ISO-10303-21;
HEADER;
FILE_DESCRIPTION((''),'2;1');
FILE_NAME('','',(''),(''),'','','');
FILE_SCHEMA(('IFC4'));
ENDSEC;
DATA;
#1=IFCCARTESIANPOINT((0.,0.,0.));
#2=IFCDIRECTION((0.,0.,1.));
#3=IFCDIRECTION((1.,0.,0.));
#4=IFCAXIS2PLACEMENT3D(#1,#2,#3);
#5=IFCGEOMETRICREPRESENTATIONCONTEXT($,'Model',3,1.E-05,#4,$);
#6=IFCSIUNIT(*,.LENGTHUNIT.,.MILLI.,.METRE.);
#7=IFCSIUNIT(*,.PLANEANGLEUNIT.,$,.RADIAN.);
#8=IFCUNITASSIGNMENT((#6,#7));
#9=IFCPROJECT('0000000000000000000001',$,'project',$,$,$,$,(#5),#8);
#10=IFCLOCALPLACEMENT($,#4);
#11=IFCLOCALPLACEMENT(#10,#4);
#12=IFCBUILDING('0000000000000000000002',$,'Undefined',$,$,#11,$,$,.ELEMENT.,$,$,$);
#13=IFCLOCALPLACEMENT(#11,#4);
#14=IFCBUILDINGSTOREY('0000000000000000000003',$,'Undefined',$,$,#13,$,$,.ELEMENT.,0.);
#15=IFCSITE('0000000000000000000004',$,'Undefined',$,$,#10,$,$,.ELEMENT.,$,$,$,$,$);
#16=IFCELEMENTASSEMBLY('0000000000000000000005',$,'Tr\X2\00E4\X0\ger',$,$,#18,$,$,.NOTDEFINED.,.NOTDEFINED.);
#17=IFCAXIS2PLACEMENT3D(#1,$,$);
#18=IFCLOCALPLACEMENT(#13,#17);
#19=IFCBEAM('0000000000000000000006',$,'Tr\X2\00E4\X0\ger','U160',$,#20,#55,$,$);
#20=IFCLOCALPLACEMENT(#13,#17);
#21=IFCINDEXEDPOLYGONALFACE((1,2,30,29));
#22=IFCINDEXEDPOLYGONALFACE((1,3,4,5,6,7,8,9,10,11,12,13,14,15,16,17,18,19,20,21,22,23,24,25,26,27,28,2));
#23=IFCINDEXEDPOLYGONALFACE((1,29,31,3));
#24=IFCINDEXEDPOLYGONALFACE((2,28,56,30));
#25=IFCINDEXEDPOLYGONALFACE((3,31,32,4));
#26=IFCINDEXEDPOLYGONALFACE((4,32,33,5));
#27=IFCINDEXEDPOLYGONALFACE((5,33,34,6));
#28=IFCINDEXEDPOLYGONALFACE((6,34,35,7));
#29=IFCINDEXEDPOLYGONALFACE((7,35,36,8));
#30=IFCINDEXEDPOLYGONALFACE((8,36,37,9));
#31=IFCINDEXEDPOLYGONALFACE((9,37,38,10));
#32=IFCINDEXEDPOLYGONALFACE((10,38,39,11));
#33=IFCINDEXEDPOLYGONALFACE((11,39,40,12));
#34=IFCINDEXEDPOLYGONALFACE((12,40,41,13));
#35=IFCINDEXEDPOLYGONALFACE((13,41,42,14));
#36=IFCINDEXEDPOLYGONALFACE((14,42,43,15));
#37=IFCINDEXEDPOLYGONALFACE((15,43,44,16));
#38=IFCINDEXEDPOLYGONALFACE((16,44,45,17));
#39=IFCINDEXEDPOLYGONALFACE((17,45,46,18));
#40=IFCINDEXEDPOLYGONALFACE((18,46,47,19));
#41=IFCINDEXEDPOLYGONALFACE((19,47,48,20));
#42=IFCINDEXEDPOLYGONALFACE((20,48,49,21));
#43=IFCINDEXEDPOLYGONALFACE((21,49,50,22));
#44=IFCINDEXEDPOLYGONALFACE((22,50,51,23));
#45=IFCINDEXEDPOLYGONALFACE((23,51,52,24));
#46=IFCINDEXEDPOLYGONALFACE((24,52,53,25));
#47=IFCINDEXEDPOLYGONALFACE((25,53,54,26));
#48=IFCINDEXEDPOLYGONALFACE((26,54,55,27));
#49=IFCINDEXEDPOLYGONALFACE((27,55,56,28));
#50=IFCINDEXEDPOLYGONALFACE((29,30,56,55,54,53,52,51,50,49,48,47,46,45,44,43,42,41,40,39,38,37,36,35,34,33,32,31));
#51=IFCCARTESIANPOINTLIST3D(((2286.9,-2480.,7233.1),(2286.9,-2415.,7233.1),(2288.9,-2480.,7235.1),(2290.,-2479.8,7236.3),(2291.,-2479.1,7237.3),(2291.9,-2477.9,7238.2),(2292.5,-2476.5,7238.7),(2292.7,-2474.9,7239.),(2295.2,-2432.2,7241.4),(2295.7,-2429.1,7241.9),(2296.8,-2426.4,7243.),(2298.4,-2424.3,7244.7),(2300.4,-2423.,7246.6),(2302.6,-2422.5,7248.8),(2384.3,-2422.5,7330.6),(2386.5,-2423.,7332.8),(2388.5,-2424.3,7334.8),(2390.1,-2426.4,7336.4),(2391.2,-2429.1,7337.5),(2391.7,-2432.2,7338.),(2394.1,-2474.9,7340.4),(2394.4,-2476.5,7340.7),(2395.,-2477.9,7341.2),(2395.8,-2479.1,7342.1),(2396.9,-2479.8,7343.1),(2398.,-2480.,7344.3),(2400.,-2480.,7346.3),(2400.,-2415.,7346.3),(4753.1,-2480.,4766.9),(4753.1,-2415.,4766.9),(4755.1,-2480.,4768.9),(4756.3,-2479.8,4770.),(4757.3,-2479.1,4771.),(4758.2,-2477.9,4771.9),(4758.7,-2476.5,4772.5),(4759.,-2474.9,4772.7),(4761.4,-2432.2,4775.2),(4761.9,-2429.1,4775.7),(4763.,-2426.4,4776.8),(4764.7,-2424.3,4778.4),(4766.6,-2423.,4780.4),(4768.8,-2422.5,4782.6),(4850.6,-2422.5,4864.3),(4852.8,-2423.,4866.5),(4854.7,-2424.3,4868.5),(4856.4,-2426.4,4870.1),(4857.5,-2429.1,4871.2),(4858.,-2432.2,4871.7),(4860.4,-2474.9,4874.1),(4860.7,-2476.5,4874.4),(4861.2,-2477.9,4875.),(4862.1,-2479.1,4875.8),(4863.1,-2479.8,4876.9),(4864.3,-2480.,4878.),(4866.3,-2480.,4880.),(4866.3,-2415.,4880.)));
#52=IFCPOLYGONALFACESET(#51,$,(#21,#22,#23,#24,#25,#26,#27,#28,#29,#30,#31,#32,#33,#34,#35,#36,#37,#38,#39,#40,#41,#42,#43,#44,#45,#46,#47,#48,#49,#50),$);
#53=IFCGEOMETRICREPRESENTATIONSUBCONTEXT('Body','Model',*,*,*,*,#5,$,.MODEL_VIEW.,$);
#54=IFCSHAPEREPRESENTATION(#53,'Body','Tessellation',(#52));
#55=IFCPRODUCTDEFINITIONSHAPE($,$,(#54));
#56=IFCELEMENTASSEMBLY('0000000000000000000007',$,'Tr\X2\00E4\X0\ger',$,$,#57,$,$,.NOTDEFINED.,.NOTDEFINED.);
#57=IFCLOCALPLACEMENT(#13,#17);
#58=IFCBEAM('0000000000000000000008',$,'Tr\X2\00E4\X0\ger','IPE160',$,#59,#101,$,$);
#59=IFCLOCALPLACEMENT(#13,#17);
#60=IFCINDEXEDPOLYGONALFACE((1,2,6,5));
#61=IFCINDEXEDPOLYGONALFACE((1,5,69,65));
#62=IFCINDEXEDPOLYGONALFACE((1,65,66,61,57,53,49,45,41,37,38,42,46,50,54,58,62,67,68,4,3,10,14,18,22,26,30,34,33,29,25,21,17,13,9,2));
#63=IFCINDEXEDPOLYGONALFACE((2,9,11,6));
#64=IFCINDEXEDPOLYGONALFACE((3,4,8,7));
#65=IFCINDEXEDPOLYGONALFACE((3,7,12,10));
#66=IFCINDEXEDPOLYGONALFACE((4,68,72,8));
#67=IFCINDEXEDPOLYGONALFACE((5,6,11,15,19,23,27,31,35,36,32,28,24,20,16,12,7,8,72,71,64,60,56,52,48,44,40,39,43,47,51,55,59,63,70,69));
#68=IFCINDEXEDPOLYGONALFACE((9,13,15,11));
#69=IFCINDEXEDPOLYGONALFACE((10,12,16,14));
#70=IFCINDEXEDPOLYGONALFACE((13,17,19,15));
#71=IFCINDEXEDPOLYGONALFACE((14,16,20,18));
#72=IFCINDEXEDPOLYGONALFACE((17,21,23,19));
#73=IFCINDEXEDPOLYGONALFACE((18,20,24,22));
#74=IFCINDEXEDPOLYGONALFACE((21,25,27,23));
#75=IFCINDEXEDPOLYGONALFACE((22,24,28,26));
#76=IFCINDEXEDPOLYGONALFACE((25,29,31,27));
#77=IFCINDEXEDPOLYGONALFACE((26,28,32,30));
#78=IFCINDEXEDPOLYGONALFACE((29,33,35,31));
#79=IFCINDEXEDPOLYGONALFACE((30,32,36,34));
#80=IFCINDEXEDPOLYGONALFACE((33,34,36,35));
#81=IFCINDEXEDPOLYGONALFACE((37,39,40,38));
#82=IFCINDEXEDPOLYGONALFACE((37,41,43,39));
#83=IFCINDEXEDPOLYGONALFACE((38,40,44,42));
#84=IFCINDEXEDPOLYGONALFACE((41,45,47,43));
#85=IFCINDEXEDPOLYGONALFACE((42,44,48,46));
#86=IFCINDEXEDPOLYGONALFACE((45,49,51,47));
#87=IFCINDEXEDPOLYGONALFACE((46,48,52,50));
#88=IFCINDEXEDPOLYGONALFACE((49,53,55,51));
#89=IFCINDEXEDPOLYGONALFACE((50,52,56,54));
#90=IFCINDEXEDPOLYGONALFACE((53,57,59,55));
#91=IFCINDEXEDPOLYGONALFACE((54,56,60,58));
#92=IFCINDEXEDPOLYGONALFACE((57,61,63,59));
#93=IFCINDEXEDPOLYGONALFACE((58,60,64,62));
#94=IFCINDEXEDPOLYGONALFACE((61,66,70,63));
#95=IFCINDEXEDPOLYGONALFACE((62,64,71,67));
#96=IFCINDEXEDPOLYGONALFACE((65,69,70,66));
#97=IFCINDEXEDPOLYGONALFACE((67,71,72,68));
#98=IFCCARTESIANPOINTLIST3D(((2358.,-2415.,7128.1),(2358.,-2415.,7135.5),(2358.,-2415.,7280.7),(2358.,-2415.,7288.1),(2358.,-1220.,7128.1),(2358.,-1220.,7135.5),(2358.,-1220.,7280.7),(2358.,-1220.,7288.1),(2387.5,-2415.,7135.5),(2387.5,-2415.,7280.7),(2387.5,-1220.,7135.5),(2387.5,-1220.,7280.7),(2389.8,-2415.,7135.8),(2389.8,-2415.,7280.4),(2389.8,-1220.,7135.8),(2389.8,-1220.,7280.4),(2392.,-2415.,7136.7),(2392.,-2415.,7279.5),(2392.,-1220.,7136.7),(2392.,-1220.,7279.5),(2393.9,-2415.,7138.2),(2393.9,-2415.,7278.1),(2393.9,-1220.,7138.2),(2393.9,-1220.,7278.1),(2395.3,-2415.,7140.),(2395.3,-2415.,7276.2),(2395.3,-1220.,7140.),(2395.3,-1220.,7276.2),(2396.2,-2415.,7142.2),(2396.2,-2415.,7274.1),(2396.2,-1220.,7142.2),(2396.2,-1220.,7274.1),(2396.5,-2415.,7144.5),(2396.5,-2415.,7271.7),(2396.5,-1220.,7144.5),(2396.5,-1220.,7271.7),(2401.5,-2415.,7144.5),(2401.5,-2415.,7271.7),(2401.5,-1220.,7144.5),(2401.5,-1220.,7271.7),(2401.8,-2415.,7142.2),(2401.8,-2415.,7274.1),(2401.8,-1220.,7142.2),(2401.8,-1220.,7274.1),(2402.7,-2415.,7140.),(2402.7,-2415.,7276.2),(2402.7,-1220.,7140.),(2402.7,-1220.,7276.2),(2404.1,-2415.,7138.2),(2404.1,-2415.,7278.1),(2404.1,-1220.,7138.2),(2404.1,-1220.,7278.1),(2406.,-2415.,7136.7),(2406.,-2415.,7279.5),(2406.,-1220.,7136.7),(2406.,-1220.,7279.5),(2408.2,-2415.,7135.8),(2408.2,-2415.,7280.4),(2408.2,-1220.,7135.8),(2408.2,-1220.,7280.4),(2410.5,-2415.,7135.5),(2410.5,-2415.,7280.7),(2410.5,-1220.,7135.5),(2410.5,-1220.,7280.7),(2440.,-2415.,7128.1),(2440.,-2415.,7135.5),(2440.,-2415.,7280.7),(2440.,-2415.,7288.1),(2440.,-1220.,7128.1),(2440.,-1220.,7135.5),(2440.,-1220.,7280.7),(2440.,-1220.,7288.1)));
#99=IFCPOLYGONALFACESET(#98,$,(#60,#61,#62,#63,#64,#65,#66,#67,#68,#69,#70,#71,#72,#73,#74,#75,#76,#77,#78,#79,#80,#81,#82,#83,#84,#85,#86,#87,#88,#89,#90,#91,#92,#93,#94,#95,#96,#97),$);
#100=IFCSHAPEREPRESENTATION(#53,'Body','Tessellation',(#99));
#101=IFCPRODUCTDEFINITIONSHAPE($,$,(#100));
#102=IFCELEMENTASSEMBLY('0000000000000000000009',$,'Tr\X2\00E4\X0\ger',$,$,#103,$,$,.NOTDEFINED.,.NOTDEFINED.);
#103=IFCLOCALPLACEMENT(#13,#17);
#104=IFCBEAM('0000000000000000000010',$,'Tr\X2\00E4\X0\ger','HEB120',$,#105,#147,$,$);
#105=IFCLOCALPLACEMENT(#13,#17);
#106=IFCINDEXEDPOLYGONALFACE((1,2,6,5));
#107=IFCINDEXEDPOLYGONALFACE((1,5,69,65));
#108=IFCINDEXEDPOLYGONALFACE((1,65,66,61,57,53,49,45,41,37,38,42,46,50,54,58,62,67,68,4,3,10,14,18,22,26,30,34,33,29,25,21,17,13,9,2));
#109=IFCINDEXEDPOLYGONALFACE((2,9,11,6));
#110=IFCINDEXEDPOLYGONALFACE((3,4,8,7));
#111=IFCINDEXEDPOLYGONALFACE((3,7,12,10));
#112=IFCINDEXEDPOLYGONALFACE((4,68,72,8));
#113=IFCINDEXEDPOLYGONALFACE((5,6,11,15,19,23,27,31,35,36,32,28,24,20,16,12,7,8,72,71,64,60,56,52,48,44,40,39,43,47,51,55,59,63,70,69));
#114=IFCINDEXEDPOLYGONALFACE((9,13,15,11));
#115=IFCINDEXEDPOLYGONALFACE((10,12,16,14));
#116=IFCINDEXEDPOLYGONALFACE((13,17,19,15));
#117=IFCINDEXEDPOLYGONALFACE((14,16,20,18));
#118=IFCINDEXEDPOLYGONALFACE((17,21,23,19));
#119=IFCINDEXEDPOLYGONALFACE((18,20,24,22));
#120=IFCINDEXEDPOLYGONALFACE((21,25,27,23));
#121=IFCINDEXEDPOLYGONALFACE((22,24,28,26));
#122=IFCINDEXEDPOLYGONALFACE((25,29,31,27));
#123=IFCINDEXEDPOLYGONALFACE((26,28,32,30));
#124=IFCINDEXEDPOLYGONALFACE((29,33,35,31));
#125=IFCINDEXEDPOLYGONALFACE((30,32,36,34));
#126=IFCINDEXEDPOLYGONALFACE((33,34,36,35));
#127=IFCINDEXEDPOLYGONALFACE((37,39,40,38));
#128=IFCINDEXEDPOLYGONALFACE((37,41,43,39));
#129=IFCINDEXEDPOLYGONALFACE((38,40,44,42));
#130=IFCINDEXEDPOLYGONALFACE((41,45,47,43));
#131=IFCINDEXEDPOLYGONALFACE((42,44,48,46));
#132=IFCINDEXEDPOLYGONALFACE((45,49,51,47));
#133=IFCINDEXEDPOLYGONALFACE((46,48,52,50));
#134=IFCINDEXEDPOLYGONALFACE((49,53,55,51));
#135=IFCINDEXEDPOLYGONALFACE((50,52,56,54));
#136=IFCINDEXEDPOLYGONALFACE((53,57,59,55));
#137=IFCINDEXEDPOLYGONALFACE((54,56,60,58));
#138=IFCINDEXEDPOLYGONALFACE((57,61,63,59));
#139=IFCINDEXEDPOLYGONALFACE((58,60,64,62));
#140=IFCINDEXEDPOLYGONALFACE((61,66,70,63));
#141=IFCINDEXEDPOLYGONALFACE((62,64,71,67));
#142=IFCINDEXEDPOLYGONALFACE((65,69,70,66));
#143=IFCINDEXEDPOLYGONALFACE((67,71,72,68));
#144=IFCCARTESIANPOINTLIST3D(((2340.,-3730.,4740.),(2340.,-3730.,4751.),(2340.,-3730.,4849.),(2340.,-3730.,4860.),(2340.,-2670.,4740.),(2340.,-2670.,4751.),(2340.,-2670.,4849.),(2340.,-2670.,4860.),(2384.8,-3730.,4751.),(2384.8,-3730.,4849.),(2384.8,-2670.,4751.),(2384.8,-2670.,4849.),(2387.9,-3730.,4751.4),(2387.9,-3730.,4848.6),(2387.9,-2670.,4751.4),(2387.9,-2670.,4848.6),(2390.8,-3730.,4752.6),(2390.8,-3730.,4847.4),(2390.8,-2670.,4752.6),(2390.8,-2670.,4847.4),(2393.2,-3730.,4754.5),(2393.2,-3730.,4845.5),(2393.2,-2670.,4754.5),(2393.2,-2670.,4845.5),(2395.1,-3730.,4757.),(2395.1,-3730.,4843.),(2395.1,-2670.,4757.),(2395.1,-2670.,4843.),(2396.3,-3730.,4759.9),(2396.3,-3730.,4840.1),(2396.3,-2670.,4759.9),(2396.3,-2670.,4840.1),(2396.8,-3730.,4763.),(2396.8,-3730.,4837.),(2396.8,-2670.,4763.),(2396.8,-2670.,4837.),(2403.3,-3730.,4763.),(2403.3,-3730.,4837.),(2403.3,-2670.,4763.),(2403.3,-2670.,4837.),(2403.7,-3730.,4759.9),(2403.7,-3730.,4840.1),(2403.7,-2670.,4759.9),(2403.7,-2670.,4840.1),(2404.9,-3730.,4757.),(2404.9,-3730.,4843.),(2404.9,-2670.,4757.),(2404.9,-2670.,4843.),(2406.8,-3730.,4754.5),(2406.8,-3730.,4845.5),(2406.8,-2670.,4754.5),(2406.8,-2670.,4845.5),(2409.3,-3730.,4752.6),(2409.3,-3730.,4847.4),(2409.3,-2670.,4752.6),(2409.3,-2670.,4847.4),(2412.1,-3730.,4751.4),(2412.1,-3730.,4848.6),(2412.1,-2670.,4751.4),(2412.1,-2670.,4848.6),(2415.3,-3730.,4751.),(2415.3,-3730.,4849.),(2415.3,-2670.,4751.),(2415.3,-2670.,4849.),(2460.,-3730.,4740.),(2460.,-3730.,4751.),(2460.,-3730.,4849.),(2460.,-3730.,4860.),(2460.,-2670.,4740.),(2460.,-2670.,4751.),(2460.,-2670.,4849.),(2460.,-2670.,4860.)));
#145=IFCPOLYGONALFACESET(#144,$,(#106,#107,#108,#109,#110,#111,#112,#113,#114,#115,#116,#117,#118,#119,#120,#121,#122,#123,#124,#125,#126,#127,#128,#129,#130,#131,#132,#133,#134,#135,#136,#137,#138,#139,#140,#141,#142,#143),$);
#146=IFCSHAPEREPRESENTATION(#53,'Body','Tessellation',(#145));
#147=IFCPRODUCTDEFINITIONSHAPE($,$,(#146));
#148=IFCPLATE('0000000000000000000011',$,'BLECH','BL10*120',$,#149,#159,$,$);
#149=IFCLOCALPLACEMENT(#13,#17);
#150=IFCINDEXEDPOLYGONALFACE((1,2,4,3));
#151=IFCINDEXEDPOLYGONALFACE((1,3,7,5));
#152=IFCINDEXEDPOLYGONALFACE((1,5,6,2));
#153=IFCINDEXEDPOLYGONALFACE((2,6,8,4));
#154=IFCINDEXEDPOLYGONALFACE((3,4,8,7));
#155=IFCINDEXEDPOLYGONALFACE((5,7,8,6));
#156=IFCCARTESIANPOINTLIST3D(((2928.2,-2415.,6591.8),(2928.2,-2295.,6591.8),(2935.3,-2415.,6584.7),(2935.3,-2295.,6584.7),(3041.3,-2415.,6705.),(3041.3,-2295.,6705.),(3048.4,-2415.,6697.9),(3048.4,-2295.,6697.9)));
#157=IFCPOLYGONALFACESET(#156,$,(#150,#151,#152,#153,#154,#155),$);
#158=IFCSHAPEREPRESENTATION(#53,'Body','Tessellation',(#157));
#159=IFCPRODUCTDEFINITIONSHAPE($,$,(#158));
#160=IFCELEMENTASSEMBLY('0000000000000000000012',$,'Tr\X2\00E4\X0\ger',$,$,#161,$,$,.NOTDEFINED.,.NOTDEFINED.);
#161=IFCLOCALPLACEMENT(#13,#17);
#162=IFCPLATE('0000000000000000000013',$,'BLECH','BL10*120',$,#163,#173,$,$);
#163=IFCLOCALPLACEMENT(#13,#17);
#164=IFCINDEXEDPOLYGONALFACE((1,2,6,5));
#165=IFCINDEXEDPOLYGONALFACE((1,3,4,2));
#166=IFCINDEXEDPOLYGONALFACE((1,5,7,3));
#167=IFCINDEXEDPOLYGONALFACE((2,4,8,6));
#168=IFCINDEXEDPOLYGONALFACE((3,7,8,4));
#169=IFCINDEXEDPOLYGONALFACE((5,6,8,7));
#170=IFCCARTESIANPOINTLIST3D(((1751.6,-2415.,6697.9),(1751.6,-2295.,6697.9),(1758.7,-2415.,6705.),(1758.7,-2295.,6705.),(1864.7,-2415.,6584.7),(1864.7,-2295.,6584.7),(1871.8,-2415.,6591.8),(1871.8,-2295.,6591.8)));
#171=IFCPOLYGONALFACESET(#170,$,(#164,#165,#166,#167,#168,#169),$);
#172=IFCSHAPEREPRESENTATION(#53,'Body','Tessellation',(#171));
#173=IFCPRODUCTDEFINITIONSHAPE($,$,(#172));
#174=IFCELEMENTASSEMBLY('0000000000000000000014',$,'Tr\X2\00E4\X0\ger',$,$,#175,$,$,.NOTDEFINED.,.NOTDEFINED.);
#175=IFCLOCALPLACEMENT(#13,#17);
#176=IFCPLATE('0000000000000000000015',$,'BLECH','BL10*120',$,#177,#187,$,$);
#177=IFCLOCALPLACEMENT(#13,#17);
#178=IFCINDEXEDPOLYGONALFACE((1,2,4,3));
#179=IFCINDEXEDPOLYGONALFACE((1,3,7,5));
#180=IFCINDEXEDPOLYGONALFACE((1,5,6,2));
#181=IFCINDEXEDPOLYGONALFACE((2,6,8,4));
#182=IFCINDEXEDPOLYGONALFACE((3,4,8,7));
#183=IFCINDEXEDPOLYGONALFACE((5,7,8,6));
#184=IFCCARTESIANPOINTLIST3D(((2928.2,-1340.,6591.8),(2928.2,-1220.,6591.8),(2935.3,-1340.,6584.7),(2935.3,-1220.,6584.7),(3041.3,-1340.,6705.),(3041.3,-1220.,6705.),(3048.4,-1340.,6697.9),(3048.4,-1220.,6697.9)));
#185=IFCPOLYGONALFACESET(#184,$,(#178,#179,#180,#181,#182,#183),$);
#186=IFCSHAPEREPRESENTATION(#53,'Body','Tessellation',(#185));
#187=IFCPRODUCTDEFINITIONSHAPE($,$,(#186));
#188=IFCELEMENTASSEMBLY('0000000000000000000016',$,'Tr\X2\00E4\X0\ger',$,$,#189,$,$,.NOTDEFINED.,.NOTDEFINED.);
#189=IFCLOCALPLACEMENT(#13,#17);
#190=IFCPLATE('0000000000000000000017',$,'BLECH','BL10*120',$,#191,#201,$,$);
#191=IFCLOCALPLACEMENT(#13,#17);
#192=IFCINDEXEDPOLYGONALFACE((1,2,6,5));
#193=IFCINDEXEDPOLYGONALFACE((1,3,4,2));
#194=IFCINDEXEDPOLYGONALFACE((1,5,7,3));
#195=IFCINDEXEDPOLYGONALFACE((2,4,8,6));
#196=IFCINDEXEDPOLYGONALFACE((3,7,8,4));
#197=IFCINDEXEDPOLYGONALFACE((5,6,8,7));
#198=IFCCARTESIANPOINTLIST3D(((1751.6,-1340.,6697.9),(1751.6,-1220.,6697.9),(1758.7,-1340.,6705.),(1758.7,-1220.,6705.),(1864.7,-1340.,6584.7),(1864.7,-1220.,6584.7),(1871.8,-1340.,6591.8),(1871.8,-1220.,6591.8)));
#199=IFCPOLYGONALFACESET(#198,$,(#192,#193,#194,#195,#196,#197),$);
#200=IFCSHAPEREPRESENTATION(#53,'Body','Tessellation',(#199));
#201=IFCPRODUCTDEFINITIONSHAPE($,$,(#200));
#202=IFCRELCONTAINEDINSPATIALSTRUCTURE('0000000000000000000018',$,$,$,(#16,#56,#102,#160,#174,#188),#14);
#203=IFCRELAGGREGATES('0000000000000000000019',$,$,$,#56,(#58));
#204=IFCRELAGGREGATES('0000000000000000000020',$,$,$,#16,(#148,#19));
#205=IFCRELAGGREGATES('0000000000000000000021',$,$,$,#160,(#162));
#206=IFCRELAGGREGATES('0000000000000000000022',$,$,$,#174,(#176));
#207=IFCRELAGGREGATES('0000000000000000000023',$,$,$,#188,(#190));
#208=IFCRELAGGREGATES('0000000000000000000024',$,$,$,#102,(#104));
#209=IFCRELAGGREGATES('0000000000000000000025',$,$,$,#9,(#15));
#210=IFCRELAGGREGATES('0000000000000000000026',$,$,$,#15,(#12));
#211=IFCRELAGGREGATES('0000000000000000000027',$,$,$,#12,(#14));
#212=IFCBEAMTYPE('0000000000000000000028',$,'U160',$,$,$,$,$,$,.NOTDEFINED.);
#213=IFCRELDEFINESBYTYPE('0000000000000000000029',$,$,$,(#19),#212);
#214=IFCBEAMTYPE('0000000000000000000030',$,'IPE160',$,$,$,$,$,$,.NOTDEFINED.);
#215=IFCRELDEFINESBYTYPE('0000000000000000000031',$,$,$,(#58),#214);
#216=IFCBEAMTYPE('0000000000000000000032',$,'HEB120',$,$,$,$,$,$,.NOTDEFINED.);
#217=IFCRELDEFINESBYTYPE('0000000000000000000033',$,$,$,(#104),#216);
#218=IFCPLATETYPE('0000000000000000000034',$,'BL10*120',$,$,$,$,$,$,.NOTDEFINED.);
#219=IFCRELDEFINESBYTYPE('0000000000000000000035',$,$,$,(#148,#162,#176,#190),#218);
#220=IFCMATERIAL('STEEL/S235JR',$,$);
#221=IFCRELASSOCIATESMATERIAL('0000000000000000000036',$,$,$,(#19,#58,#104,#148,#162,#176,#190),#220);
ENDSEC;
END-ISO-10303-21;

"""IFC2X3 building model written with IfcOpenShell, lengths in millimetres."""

from ifc_helpers import new_model, si_unit, frame, origin_with_axes, origin_2d_with_axis, place, context, subcontext, project, spatial, polyline, i_section, u_section, outline, extrude, clip, halfspace, material, type_object, element, aggregate, save


model = new_model("IFC2X3")

# Units and contexts
model_context = context("Model", 3, precision=1e-05, world=origin_with_axes())
body_context = subcontext(model_context, "Body", "Model", "MODEL_VIEW")
ifc_project = project(units=[si_unit("LENGTHUNIT", "METRE", prefix="MILLI"), si_unit("PLANEANGLEUNIT", "RADIAN")], contexts=[model_context])

# Site, building, storey
site_placement = place(None, origin_with_axes())
site = spatial("IfcSite", under=ifc_project, at=site_placement, Name="Undefined", CompositionType="ELEMENT")
building_placement = place(site_placement, origin_with_axes())
building = spatial("IfcBuilding", under=site, at=building_placement, Name="Undefined", CompositionType="ELEMENT")
storey_placement = place(building_placement, origin_with_axes())
storey = spatial("IfcBuildingStorey", under=building, at=storey_placement, Name="Undefined", CompositionType="ELEMENT", Elevation=0.0)

# Element assemblies, beams
assembly_1_placement = place(storey_placement, origin_with_axes())
assembly_1 = element("IfcElementAssembly", 1, at=assembly_1_placement, inside=storey, Name="Träger", AssemblyPlace="NOTDEFINED", PredefinedType="NOTDEFINED")
ifc_material_1 = material(Name="STEEL/S235JR")
beam_type_1 = type_object("IfcBeamType", Name="U160", PredefinedType="NOTDEFINED")
beam_1_placement = place(assembly_1_placement, frame((2343.4, -2447.5, 7289.7), z_axis=(0.707107, 0.0, 0.707107), x_axis=(0.707107, 0.0, -0.707107)))
beam_1 = element("IfcBeam", 2, at=beam_1_placement, type_object=beam_type_1, material=ifc_material_1, Name="Träger", Description="U160", context=body_context, shape_type="SweptSolid", body=[
    extrude(u_section(Depth=160.0, FlangeWidth=65.0, WebThickness=7.5, FlangeThickness=10.5, FilletRadius=10.5, EdgeRadius=5.5, FlangeSlope=0.07983, at=origin_2d_with_axis()), frame((3487.8, 0.0, 0.0), z_axis=(-1.0, 0.0, 0.0), x_axis=(0.0, -1.0, 0.0)), (0.0, 0.0, 1.0), 3487.8),
])
assembly_2_placement = place(storey_placement, origin_with_axes())
assembly_2 = element("IfcElementAssembly", 3, at=assembly_2_placement, inside=storey, Name="Träger", AssemblyPlace="NOTDEFINED", PredefinedType="NOTDEFINED")
beam_type_2 = type_object("IfcBeamType", Name="IPE160", PredefinedType="NOTDEFINED")
beam_2_placement = place(assembly_2_placement, frame((2399.0, -1220.0, 7208.1), z_axis=(0.0, 0.0, 1.0), x_axis=(0.0, -1.0, 0.0)))
beam_2 = element("IfcBeam", 4, at=beam_2_placement, type_object=beam_type_2, material=ifc_material_1, Name="Träger", Description="IPE160", context=body_context, shape_type="SweptSolid", body=[
    extrude(i_section(OverallWidth=82.0, OverallDepth=160.0, WebThickness=5.0, FlangeThickness=7.4, FilletRadius=9.0, at=origin_2d_with_axis()), frame((1195.0, 0.0, 0.0), z_axis=(-1.0, 0.0, 0.0), x_axis=(0.0, -1.0, 0.0)), (0.0, 0.0, 1.0), 1195.0),
])
aggregate(assembly_2, [beam_2])
beam_type_3 = type_object("IfcBeamType", Name="HEB120", PredefinedType="NOTDEFINED")

# Element assembly, beam
assembly_3_placement = place(storey_placement, origin_with_axes())
assembly_3 = element("IfcElementAssembly", 5, at=assembly_3_placement, inside=storey, Name="Träger", AssemblyPlace="NOTDEFINED", PredefinedType="NOTDEFINED")
beam_3_placement = place(assembly_3_placement, frame((2400.0, -2670.0, 4800.0), z_axis=(0.0, 0.0, 1.0), x_axis=(0.0, -1.0, 0.0)))
beam_3 = element("IfcBeam", 6, at=beam_3_placement, type_object=beam_type_3, material=ifc_material_1, Name="Träger", Description="HEB120", context=body_context, shape_type="Clipping", body=[
    clip(clip(extrude(i_section(OverallWidth=120.0, OverallDepth=120.0, WebThickness=6.5, FlangeThickness=11.0, FilletRadius=12.0, at=origin_2d_with_axis()), frame((1060.0, 0.0, 0.0), z_axis=(-1.0, 0.0, 0.0), x_axis=(0.0, -1.0, 0.0)), (0.0, 0.0, 1.0), 1060.0), halfspace(frame((1060.0, 0.0, -60.0), z_axis=(-1.0, 0.0, 0.0), x_axis=(0.0, 1.0, 0.0)), True)), halfspace(frame((0.0, 0.0, -60.0), z_axis=(1.0, 0.0, 0.0), x_axis=(0.0, -1.0, 0.0)), True)),
])

# Plate
plate_type = type_object("IfcPlateType", Name="BL10*120", PredefinedType="NOTDEFINED")
plate_1_placement = place(assembly_1_placement, frame((2931.7, -2295.0, 6588.3), z_axis=(-0.707107, 0.0, 0.707107), x_axis=(0.0, -1.0, 0.0)))
plate_1 = element("IfcPlate", 7, at=plate_1_placement, type_object=plate_type, material=ifc_material_1, Name="BLECH", Description="BL10*120", context=body_context, shape_type="SweptSolid", body=[
    extrude(outline(polyline([(0.0, 0.0), (120.0, 0.0), (120.0, 160.0), (0.0, 160.0), (0.0, 0.0)])), frame((0.0, 0.0, -5.0), z_axis=(0.0, 0.0, 1.0), x_axis=(1.0, 0.0, 0.0)), (0.0, 0.0, 1.0), 10.0),
])

# Element assemblies, plates
assembly_4_placement = place(storey_placement, origin_with_axes())
assembly_4 = element("IfcElementAssembly", 8, at=assembly_4_placement, inside=storey, Name="Träger", AssemblyPlace="NOTDEFINED", PredefinedType="NOTDEFINED")
plate_2_placement = place(assembly_4_placement, frame((1868.3, -2295.0, 6588.3), z_axis=(-0.707107, 0.0, -0.707107), x_axis=(0.0, -1.0, 0.0)))
plate_2 = element("IfcPlate", 9, at=plate_2_placement, type_object=plate_type, material=ifc_material_1, Name="BLECH", Description="BL10*120", context=body_context, shape_type="SweptSolid", body=[
    extrude(outline(polyline([(0.0, 0.0), (120.0, 0.0), (120.0, 160.0), (0.0, 160.0), (0.0, 0.0)])), frame((0.0, 0.0, -5.0), z_axis=(0.0, 0.0, 1.0), x_axis=(1.0, 0.0, 0.0)), (0.0, 0.0, 1.0), 10.0),
])
assembly_5_placement = place(storey_placement, origin_with_axes())
assembly_5 = element("IfcElementAssembly", 10, at=assembly_5_placement, inside=storey, Name="Träger", AssemblyPlace="NOTDEFINED", PredefinedType="NOTDEFINED")
plate_3_placement = place(assembly_5_placement, frame((2931.7, -1340.0, 6588.3), z_axis=(0.707107, 0.0, -0.707107), x_axis=(0.0, 1.0, 0.0)))
plate_3 = element("IfcPlate", 11, at=plate_3_placement, type_object=plate_type, material=ifc_material_1, Name="BLECH", Description="BL10*120", context=body_context, shape_type="SweptSolid", body=[
    extrude(outline(polyline([(0.0, 0.0), (120.0, 0.0), (120.0, 160.0), (0.0, 160.0), (0.0, 0.0)])), frame((0.0, 0.0, -5.0), z_axis=(0.0, 0.0, 1.0), x_axis=(1.0, 0.0, 0.0)), (0.0, 0.0, 1.0), 10.0),
])
assembly_6_placement = place(storey_placement, origin_with_axes())
assembly_6 = element("IfcElementAssembly", 12, at=assembly_6_placement, inside=storey, Name="Träger", AssemblyPlace="NOTDEFINED", PredefinedType="NOTDEFINED")
plate_4_placement = place(assembly_6_placement, frame((1868.3, -1340.0, 6588.3), z_axis=(0.707107, 0.0, 0.707107), x_axis=(0.0, 1.0, 0.0)))
plate_4 = element("IfcPlate", 13, at=plate_4_placement, type_object=plate_type, material=ifc_material_1, Name="BLECH", Description="BL10*120", context=body_context, shape_type="SweptSolid", body=[
    extrude(outline(polyline([(0.0, 0.0), (120.0, 0.0), (120.0, 160.0), (0.0, 160.0), (0.0, 0.0)])), frame((0.0, 0.0, -5.0), z_axis=(0.0, 0.0, 1.0), x_axis=(1.0, 0.0, 0.0)), (0.0, 0.0, 1.0), 10.0),
])

aggregate(assembly_1, [plate_1, beam_1])
aggregate(assembly_4, [plate_2])
aggregate(assembly_5, [plate_3])
aggregate(assembly_6, [plate_4])

aggregate(assembly_3, [beam_3])

save(model, "model.ifc")
